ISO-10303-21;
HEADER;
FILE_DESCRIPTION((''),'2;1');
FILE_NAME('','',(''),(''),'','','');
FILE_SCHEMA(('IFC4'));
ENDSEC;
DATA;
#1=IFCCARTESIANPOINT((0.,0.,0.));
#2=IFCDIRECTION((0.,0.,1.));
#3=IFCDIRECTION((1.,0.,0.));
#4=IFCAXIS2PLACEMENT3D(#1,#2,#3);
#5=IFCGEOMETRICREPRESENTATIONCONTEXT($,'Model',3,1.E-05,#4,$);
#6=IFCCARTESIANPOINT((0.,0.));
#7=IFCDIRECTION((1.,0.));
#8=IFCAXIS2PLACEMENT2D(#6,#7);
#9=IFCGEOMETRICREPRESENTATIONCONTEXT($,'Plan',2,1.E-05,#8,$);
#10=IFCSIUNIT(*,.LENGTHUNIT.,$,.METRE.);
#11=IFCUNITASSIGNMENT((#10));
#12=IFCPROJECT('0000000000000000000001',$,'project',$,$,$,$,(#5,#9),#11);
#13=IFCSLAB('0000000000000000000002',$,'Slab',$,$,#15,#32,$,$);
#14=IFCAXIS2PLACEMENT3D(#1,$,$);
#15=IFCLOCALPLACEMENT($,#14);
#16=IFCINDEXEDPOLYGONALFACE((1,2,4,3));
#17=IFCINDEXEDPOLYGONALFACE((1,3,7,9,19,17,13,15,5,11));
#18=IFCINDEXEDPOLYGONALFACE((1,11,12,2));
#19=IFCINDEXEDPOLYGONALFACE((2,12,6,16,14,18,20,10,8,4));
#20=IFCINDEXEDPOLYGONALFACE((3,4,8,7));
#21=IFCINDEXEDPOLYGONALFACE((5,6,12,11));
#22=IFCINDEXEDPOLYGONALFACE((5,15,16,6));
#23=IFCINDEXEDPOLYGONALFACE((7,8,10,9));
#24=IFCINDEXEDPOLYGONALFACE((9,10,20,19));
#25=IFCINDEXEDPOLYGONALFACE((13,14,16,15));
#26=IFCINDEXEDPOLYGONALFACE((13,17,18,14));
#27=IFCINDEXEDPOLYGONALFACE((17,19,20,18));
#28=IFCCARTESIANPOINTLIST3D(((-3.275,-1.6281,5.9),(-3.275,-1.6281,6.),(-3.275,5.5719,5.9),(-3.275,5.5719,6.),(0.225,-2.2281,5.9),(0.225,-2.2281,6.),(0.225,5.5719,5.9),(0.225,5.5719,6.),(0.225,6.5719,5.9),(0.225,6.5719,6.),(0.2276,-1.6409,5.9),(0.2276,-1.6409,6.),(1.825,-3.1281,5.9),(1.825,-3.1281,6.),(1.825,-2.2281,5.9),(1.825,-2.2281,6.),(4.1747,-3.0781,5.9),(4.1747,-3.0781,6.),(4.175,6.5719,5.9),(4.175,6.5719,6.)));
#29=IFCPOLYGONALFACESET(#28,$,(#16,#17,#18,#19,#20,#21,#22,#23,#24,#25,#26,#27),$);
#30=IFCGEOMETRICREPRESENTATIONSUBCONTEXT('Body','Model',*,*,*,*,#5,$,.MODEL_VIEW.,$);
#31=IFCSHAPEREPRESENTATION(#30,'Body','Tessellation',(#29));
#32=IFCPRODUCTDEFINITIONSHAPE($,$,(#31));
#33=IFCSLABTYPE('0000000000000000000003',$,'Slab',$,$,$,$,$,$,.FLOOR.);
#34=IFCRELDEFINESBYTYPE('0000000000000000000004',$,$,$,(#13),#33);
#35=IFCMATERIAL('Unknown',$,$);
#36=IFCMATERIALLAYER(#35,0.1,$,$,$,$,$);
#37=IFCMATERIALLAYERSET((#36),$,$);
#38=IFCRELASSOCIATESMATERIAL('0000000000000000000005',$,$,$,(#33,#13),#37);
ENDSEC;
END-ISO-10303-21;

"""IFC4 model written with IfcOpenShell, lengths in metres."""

from ifc_helpers import new_model, si_unit, frame, origin_with_axes, origin_2d_with_axis, place, context, subcontext, project, indexed_curve, outline, extrude, material, layer, layer_set, layer_usage, type_object, element, save


model = new_model("IFC4")

# Units and contexts
model_context = context("Model", 3, precision=1e-05, world=origin_with_axes())
plan_context = context("Plan", 2, precision=1e-05, world=origin_2d_with_axis())
body_context = subcontext(model_context, "Body", "Model", "MODEL_VIEW")
ifc_project = project(units=[si_unit("LENGTHUNIT", "METRE")], contexts=[model_context, plan_context])

# Slab
ifc_material = material(Name="Unknown")
ifc_layer = layer(ifc_material, 0.1)
ifc_layer_set = layer_set([ifc_layer])
ifc_layer_usage = layer_usage(ifc_layer_set, "AXIS3", "POSITIVE", -0.1)
slab_type = type_object("IfcSlabType", Name="Slab", PredefinedType="FLOOR", material=ifc_layer_set)
placement_1 = place(None, origin_with_axes())
placement_2 = place(placement_1, origin_with_axes())
placement_3 = place(placement_2, origin_with_axes())
slab_placement = place(placement_3, frame((4.175, 6.5719, 6.0), z_axis=(0.0, 0.0, 1.0), x_axis=(1.0, 0.0, 0.0)))
element("IfcSlab", 1, at=slab_placement, type_object=slab_type, material=ifc_layer_usage, Name="Slab", context=body_context, shape_type="SweptSolid", body=[
    extrude(outline(indexed_curve([(0.0, 0.0), (-3.95, 0.0), (-3.95, -1.0), (-7.45, -1.0), (-7.45, -8.2), (-3.9474, -8.2128), (-3.95, -8.8), (-2.35, -8.8), (-2.35, -9.7), (-0.0003, -9.65), (0.0, 0.0)])), frame((0.0, 0.0, -0.1), z_axis=(0.0, 0.0, 1.0), x_axis=(1.0, 0.0, 0.0)), (0.0, 0.0, 1.0), 0.1),
])

save(model, "model.ifc")
